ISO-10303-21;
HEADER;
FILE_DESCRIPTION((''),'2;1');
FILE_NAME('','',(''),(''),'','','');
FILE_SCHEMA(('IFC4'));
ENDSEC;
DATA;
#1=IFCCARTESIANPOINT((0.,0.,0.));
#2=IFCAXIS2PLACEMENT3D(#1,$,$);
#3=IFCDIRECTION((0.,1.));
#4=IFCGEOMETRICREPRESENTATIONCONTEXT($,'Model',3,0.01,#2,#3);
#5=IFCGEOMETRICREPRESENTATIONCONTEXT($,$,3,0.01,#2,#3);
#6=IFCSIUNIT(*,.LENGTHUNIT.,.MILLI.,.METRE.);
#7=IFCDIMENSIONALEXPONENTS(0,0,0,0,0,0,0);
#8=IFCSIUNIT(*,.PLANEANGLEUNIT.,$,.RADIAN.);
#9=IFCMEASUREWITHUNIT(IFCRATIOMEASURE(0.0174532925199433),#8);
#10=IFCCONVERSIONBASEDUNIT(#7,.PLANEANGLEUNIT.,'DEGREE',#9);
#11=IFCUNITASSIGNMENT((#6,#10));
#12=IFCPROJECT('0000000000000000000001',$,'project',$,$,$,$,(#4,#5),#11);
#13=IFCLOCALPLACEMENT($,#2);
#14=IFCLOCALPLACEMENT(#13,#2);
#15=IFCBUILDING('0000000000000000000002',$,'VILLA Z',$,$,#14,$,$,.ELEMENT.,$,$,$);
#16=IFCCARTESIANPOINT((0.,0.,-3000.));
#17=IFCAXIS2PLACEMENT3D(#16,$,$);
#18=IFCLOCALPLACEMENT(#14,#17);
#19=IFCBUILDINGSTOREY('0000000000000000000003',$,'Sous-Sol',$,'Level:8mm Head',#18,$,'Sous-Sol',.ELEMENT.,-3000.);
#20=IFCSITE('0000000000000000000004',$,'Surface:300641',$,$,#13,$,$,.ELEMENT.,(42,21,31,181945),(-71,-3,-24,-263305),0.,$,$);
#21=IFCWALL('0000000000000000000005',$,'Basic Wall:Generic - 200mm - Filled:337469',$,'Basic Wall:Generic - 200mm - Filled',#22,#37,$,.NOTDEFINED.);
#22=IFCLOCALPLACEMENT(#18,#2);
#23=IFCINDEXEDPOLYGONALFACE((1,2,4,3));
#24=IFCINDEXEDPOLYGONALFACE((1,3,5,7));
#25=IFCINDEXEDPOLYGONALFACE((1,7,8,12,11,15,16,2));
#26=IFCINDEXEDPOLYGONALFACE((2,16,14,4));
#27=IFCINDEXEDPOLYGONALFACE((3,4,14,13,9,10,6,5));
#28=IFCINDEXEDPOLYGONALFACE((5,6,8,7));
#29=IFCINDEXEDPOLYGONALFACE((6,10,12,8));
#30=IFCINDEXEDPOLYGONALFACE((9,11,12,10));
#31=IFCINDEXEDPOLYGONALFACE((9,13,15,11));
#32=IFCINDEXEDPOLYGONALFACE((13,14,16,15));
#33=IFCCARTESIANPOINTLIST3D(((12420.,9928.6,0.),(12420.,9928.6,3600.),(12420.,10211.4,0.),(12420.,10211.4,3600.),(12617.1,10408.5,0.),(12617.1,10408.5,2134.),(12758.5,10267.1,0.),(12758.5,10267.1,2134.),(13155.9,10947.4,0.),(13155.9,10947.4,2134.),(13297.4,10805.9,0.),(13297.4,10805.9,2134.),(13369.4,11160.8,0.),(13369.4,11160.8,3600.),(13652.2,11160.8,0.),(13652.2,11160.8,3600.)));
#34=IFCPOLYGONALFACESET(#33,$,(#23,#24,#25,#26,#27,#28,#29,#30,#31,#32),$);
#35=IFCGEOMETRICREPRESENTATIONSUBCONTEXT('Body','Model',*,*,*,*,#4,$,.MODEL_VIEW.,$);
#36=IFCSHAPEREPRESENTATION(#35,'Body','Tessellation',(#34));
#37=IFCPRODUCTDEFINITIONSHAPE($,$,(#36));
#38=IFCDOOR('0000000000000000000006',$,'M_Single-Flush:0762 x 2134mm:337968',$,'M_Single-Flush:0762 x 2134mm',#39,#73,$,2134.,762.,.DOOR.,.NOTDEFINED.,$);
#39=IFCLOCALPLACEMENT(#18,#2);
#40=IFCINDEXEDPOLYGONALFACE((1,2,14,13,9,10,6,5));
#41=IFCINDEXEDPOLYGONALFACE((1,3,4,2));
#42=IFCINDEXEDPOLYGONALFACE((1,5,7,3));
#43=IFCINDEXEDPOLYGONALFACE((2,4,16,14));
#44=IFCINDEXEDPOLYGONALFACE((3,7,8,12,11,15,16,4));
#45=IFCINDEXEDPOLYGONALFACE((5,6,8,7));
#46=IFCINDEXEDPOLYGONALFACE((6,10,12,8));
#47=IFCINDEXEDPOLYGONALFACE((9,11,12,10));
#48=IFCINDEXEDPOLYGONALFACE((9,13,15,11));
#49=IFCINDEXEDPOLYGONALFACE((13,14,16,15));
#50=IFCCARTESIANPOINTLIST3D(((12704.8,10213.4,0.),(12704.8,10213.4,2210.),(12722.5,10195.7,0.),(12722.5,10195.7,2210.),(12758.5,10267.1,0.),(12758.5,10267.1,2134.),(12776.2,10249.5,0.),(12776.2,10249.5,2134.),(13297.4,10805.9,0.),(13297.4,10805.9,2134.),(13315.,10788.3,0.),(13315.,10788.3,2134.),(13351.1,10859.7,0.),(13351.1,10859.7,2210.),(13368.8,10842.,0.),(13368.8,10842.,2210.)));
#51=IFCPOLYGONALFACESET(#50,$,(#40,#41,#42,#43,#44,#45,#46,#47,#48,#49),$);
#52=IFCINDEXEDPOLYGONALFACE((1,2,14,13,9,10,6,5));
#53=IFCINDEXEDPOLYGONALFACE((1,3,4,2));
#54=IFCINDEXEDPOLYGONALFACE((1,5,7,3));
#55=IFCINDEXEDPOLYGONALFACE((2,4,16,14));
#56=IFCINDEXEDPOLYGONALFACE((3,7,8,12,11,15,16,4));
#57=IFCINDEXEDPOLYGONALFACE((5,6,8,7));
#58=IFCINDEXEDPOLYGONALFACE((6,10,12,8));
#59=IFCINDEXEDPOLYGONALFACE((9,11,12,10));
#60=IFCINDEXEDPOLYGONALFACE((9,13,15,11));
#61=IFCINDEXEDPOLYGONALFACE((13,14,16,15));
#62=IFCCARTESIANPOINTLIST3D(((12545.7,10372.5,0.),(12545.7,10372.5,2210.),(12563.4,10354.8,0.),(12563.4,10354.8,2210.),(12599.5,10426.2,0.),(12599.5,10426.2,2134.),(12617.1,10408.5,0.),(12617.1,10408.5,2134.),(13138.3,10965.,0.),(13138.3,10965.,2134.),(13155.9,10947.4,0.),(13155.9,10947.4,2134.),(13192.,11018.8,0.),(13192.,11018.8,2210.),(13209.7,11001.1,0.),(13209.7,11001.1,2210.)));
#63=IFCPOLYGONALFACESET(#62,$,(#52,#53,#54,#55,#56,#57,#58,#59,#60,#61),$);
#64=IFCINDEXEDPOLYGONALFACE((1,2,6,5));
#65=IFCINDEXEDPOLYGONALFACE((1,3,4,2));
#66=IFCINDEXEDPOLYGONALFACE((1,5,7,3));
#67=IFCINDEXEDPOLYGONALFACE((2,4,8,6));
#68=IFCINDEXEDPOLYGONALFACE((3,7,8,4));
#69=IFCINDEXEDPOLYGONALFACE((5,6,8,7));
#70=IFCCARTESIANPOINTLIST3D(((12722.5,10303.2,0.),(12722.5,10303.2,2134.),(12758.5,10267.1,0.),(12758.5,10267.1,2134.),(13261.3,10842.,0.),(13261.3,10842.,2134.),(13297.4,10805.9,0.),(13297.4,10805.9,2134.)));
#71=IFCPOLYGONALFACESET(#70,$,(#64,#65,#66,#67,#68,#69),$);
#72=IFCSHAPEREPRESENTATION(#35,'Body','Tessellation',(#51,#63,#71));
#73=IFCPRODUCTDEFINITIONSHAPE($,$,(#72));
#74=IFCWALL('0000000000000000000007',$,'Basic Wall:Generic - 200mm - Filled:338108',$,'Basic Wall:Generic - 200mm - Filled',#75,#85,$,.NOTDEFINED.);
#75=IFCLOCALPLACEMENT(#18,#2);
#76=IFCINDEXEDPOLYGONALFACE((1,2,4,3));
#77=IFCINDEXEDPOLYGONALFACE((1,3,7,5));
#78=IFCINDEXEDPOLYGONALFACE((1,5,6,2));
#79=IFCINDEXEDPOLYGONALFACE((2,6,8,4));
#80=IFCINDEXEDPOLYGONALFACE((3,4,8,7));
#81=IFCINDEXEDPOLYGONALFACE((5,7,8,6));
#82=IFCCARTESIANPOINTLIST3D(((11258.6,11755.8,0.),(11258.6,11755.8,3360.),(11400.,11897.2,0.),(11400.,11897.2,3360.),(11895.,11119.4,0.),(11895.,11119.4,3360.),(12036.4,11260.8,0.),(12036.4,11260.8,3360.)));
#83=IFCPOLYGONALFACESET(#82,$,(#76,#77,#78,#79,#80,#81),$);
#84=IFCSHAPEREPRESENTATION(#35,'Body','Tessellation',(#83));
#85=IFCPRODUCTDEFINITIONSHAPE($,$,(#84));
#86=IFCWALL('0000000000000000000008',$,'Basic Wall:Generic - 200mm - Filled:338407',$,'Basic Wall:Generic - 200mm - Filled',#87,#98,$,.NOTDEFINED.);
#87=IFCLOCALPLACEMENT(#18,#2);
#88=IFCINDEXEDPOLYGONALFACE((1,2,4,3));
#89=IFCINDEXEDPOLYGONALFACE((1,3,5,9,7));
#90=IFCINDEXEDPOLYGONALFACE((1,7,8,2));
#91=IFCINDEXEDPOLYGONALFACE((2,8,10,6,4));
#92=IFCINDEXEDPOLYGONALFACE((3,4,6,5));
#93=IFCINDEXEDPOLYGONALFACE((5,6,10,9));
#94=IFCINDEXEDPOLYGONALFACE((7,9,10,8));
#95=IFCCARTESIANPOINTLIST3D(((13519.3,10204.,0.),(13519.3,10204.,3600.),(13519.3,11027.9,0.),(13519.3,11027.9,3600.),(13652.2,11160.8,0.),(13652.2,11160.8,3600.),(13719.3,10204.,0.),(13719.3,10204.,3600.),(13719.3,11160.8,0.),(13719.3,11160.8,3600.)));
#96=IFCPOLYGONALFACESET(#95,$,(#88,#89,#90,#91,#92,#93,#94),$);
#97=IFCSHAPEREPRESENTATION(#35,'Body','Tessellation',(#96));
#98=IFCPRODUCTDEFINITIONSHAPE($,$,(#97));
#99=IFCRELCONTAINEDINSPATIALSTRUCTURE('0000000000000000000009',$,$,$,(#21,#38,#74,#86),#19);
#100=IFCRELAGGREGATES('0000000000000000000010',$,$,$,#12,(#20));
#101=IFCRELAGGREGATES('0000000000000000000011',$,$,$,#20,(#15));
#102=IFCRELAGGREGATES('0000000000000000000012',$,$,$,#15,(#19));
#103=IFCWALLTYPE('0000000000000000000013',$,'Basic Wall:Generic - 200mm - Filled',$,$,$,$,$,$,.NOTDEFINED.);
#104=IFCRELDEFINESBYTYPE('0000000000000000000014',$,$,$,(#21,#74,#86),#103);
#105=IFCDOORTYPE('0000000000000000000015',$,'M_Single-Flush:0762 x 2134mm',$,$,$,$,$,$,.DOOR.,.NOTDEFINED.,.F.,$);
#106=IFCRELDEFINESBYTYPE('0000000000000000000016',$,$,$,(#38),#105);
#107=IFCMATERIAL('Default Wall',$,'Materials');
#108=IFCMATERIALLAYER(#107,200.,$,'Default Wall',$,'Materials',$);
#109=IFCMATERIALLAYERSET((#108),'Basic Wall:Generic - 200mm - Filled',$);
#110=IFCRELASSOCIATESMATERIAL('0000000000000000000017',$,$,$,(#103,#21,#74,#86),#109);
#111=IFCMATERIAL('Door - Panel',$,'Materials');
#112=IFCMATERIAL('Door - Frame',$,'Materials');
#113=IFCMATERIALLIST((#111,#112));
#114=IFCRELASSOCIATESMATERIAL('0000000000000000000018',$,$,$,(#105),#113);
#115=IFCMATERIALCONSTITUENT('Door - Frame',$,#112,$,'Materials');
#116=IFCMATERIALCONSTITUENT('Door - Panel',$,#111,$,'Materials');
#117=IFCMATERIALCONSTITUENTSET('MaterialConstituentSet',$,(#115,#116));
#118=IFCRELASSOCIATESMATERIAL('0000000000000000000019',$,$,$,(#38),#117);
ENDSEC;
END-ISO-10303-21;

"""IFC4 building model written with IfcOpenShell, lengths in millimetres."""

from ifc_helpers import new_model, entity, si_unit, converted_unit, direction, frame, frame_2d, origin, place, context, subcontext, project, spatial, polyline, rectangle, outline, extrude, clip, bounded_halfspace, source, transform, mapped, material, material_list, layer, layer_set, layer_usage, constituent, constituent_set, type_object, type_shapes, element, fill, save


model = new_model("IFC4")

# Units and contexts
model_context = context("Model", 3, precision=0.01, world=origin(), true_north=direction((0.0, 1.0)))
context_of_model = context(None, 3, precision=0.01, world=origin(), true_north=direction((0.0, 1.0)))
body_context = subcontext(model_context, "Body", "Model", "MODEL_VIEW")
ifc_project = project(units=[si_unit("LENGTHUNIT", "METRE", prefix="MILLI"), converted_unit("PLANEANGLEUNIT", "DEGREE", entity("IfcRatioMeasure", 0.0174532925199433), si_unit("PLANEANGLEUNIT", "RADIAN"), dimensions=[0, 0, 0, 0, 0, 0, 0])], contexts=[model_context, context_of_model])

# Site, building, storey
site_placement = place(None, origin())
site = spatial("IfcSite", under=ifc_project, at=site_placement, Name="Surface:300641", CompositionType="ELEMENT", RefLatitude=(42, 21, 31, 181945), RefLongitude=(-71, -3, -24, -263305), RefElevation=0.0)
building_placement = place(site_placement, origin())
building = spatial("IfcBuilding", under=site, at=building_placement, Name="VILLA Z", CompositionType="ELEMENT")
storey_placement = place(building_placement, frame((0.0, 0.0, -3000.0)))
storey = spatial("IfcBuildingStorey", under=building, at=storey_placement, Name="Sous-Sol", ObjectType="Level:8mm Head", LongName="Sous-Sol", CompositionType="ELEMENT", Elevation=-3000.0)

# Shared definitions
ifc_material_1 = material(Name="Default Wall", Category="Materials")

# Shared definitions
ifc_layer_1 = layer(ifc_material_1, 200.0, Name="Default Wall", Category="Materials")
ifc_layer_set_1 = layer_set([ifc_layer_1], Name="Basic Wall:Generic - 200mm - Filled")
wall_type_1 = type_object("IfcWallType", Name="Basic Wall:Generic - 200mm - Filled", PredefinedType="NOTDEFINED", material=ifc_layer_set_1)

# Wall, opening, door
ifc_layer_usage_1 = layer_usage(ifc_layer_set_1, "AXIS2", "NEGATIVE", 100.0)
wall_1_placement = place(storey_placement, frame((12349.3, 9999.3, 0.0), z_axis=(0.0, 0.0, 1.0), x_axis=(0.707107, 0.707107, 0.0)))
wall_1 = element("IfcWall", 1, at=wall_1_placement, inside=storey, type_object=wall_type_1, material=ifc_layer_usage_1, Name="Basic Wall:Generic - 200mm - Filled:337469", ObjectType="Basic Wall:Generic - 200mm - Filled", PredefinedType="NOTDEFINED", context=body_context, shape_type="SweptSolid", body=[
    extrude(outline(polyline([(0.0, -100.0), (1554.7, -100.0), (1742.7, -100.0), (1542.7, 100.0), (200.0, 100.0), (0.0, -100.0)])), origin(), (0.0, 0.0, 1.0), 3600.0),
])
opening_1_placement = place(wall_1_placement, frame((1240.8, 100.0, 0.0)))
opening_1 = element("IfcOpeningElement", 2, at=opening_1_placement, cuts=wall_1, ObjectType="Opening", PredefinedType="OPENING", context=body_context, shape_type="SweptSolid", body=[
    extrude(rectangle(XDim=762.0, YDim=2134.0, at=frame_2d((1067.0, 381.0), x_axis=(0.0, 1.0))), frame((0.0, 0.0, 0.0), z_axis=(0.0, -1.0, 0.0), x_axis=(0.0, 0.0, 1.0)), (0.0, 0.0, 1.0), 200.0),
])
ifc_material_2 = material(Name="Door - Frame", Category="Materials")
ifc_constituent_1 = constituent(ifc_material_2, Name="Door - Frame", Category="Materials")
ifc_material_3 = material(Name="Door - Panel", Category="Materials")
ifc_constituent_2 = constituent(ifc_material_3, Name="Door - Panel", Category="Materials")
ifc_constituent_set_1 = constituent_set(constituents=[ifc_constituent_1, ifc_constituent_2], Name="MaterialConstituentSet")
ifc_material_list_1 = material_list([ifc_material_3, ifc_material_2])
door_type = type_object("IfcDoorType", Name="M_Single-Flush:0762 x 2134mm", OperationType="NOTDEFINED", ParameterTakesPrecedence=False, PredefinedType="DOOR", material=ifc_material_list_1)
shared_shape_1 = source(origin(), body_context, "Body", "SweptSolid", [
    extrude(outline(polyline([(-457.0, -1124.0), (457.0, -1124.0), (457.0, 1086.0), (381.0, 1086.0), (381.0, -1048.0), (-381.0, -1048.0), (-381.0, 1086.0), (-457.0, 1086.0), (-457.0, -1124.0)])), frame((381.0, 200.0, 1086.0), z_axis=(0.0, 1.0, 0.0), x_axis=(1.0, 0.0, 0.0)), (0.0, 0.0, 1.0), 25.0),
    extrude(outline(polyline([(-1124.0, -457.0), (1086.0, -457.0), (1086.0, -381.0), (-1048.0, -381.0), (-1048.0, 381.0), (1086.0, 381.0), (1086.0, 457.0), (-1124.0, 457.0), (-1124.0, -457.0)])), frame((381.0, -25.0, 1086.0), z_axis=(0.0, 1.0, 0.0), x_axis=(0.0, 0.0, -1.0)), (0.0, 0.0, 1.0), 25.0),
    extrude(rectangle(XDim=51.0, YDim=762.0, at=frame_2d((0.0, 0.0), x_axis=(1.0, 0.0))), frame((381.0, 174.5, 0.0), z_axis=(0.0, 0.0, 1.0), x_axis=(0.0, 1.0, 0.0)), (0.0, 0.0, 1.0), 2134.0),
])
type_shapes(door_type, [shared_shape_1])
door_placement = place(opening_1_placement, frame((0.0, 0.0, 0.0), z_axis=(0.0, 0.0, 1.0), x_axis=(-1.0, 0.0, 0.0)))
door = element("IfcDoor", 3, at=door_placement, inside=storey, type_object=door_type, material=ifc_constituent_set_1, Name="M_Single-Flush:0762 x 2134mm:337968", ObjectType="M_Single-Flush:0762 x 2134mm", OperationType="NOTDEFINED", OverallHeight=2134.0, OverallWidth=762.0, PredefinedType="DOOR", context=body_context, shape_type="MappedRepresentation", body=[
    mapped(shared_shape_1, transform((0.0, 0.0, 0.0), scale=1.0)),
])
fill(opening_1, door)

# Walls
ifc_layer_usage_2 = layer_usage(ifc_layer_set_1, "AXIS2", "NEGATIVE", 100.0)
wall_2_placement = place(storey_placement, frame((11965.7, 11190.1, 0.0), z_axis=(0.0, 0.0, 1.0), x_axis=(-0.707107, 0.707107, 0.0)))
element("IfcWall", 4, at=wall_2_placement, inside=storey, type_object=wall_type_1, material=ifc_layer_usage_2, Name="Basic Wall:Generic - 200mm - Filled:338108", ObjectType="Basic Wall:Generic - 200mm - Filled", PredefinedType="NOTDEFINED", context=body_context, shape_type="Clipping", body=[
    clip(extrude(rectangle(XDim=900.0, YDim=200.0, at=frame_2d((450.0, 0.0), x_axis=(-1.0, 0.0))), origin(), (0.0, 0.0, 1.0), 3360.0), bounded_halfspace(frame((0.0, -100.0, 3360.0), z_axis=(0.0, 0.0, -1.0), x_axis=(-0.707107, 0.707107, 0.0)), True, frame((0.0, -100.0, 3360.0)), polyline([(0.0, 0.0), (200.0, 0.0), (900.0, 0.0), (900.0, 200.0), (0.0, 200.0), (0.0, 0.0)]))),
])
ifc_layer_usage_3 = layer_usage(ifc_layer_set_1, "AXIS2", "NEGATIVE", 100.0)
wall_3_placement = place(storey_placement, frame((13619.3, 11160.8, 0.0), z_axis=(0.0, 0.0, 1.0), x_axis=(0.0, -1.0, 0.0)))
element("IfcWall", 5, at=wall_3_placement, inside=storey, type_object=wall_type_1, material=ifc_layer_usage_3, Name="Basic Wall:Generic - 200mm - Filled:338407", ObjectType="Basic Wall:Generic - 200mm - Filled", PredefinedType="NOTDEFINED", context=body_context, shape_type="SweptSolid", body=[
    extrude(outline(polyline([(956.8, -100.0), (956.8, 100.0), (0.0, 100.0), (0.0, 32.9), (132.9, -100.0), (956.8, -100.0)])), origin(), (0.0, 0.0, 1.0), 3600.0),
])

save(model, "model.ifc")
